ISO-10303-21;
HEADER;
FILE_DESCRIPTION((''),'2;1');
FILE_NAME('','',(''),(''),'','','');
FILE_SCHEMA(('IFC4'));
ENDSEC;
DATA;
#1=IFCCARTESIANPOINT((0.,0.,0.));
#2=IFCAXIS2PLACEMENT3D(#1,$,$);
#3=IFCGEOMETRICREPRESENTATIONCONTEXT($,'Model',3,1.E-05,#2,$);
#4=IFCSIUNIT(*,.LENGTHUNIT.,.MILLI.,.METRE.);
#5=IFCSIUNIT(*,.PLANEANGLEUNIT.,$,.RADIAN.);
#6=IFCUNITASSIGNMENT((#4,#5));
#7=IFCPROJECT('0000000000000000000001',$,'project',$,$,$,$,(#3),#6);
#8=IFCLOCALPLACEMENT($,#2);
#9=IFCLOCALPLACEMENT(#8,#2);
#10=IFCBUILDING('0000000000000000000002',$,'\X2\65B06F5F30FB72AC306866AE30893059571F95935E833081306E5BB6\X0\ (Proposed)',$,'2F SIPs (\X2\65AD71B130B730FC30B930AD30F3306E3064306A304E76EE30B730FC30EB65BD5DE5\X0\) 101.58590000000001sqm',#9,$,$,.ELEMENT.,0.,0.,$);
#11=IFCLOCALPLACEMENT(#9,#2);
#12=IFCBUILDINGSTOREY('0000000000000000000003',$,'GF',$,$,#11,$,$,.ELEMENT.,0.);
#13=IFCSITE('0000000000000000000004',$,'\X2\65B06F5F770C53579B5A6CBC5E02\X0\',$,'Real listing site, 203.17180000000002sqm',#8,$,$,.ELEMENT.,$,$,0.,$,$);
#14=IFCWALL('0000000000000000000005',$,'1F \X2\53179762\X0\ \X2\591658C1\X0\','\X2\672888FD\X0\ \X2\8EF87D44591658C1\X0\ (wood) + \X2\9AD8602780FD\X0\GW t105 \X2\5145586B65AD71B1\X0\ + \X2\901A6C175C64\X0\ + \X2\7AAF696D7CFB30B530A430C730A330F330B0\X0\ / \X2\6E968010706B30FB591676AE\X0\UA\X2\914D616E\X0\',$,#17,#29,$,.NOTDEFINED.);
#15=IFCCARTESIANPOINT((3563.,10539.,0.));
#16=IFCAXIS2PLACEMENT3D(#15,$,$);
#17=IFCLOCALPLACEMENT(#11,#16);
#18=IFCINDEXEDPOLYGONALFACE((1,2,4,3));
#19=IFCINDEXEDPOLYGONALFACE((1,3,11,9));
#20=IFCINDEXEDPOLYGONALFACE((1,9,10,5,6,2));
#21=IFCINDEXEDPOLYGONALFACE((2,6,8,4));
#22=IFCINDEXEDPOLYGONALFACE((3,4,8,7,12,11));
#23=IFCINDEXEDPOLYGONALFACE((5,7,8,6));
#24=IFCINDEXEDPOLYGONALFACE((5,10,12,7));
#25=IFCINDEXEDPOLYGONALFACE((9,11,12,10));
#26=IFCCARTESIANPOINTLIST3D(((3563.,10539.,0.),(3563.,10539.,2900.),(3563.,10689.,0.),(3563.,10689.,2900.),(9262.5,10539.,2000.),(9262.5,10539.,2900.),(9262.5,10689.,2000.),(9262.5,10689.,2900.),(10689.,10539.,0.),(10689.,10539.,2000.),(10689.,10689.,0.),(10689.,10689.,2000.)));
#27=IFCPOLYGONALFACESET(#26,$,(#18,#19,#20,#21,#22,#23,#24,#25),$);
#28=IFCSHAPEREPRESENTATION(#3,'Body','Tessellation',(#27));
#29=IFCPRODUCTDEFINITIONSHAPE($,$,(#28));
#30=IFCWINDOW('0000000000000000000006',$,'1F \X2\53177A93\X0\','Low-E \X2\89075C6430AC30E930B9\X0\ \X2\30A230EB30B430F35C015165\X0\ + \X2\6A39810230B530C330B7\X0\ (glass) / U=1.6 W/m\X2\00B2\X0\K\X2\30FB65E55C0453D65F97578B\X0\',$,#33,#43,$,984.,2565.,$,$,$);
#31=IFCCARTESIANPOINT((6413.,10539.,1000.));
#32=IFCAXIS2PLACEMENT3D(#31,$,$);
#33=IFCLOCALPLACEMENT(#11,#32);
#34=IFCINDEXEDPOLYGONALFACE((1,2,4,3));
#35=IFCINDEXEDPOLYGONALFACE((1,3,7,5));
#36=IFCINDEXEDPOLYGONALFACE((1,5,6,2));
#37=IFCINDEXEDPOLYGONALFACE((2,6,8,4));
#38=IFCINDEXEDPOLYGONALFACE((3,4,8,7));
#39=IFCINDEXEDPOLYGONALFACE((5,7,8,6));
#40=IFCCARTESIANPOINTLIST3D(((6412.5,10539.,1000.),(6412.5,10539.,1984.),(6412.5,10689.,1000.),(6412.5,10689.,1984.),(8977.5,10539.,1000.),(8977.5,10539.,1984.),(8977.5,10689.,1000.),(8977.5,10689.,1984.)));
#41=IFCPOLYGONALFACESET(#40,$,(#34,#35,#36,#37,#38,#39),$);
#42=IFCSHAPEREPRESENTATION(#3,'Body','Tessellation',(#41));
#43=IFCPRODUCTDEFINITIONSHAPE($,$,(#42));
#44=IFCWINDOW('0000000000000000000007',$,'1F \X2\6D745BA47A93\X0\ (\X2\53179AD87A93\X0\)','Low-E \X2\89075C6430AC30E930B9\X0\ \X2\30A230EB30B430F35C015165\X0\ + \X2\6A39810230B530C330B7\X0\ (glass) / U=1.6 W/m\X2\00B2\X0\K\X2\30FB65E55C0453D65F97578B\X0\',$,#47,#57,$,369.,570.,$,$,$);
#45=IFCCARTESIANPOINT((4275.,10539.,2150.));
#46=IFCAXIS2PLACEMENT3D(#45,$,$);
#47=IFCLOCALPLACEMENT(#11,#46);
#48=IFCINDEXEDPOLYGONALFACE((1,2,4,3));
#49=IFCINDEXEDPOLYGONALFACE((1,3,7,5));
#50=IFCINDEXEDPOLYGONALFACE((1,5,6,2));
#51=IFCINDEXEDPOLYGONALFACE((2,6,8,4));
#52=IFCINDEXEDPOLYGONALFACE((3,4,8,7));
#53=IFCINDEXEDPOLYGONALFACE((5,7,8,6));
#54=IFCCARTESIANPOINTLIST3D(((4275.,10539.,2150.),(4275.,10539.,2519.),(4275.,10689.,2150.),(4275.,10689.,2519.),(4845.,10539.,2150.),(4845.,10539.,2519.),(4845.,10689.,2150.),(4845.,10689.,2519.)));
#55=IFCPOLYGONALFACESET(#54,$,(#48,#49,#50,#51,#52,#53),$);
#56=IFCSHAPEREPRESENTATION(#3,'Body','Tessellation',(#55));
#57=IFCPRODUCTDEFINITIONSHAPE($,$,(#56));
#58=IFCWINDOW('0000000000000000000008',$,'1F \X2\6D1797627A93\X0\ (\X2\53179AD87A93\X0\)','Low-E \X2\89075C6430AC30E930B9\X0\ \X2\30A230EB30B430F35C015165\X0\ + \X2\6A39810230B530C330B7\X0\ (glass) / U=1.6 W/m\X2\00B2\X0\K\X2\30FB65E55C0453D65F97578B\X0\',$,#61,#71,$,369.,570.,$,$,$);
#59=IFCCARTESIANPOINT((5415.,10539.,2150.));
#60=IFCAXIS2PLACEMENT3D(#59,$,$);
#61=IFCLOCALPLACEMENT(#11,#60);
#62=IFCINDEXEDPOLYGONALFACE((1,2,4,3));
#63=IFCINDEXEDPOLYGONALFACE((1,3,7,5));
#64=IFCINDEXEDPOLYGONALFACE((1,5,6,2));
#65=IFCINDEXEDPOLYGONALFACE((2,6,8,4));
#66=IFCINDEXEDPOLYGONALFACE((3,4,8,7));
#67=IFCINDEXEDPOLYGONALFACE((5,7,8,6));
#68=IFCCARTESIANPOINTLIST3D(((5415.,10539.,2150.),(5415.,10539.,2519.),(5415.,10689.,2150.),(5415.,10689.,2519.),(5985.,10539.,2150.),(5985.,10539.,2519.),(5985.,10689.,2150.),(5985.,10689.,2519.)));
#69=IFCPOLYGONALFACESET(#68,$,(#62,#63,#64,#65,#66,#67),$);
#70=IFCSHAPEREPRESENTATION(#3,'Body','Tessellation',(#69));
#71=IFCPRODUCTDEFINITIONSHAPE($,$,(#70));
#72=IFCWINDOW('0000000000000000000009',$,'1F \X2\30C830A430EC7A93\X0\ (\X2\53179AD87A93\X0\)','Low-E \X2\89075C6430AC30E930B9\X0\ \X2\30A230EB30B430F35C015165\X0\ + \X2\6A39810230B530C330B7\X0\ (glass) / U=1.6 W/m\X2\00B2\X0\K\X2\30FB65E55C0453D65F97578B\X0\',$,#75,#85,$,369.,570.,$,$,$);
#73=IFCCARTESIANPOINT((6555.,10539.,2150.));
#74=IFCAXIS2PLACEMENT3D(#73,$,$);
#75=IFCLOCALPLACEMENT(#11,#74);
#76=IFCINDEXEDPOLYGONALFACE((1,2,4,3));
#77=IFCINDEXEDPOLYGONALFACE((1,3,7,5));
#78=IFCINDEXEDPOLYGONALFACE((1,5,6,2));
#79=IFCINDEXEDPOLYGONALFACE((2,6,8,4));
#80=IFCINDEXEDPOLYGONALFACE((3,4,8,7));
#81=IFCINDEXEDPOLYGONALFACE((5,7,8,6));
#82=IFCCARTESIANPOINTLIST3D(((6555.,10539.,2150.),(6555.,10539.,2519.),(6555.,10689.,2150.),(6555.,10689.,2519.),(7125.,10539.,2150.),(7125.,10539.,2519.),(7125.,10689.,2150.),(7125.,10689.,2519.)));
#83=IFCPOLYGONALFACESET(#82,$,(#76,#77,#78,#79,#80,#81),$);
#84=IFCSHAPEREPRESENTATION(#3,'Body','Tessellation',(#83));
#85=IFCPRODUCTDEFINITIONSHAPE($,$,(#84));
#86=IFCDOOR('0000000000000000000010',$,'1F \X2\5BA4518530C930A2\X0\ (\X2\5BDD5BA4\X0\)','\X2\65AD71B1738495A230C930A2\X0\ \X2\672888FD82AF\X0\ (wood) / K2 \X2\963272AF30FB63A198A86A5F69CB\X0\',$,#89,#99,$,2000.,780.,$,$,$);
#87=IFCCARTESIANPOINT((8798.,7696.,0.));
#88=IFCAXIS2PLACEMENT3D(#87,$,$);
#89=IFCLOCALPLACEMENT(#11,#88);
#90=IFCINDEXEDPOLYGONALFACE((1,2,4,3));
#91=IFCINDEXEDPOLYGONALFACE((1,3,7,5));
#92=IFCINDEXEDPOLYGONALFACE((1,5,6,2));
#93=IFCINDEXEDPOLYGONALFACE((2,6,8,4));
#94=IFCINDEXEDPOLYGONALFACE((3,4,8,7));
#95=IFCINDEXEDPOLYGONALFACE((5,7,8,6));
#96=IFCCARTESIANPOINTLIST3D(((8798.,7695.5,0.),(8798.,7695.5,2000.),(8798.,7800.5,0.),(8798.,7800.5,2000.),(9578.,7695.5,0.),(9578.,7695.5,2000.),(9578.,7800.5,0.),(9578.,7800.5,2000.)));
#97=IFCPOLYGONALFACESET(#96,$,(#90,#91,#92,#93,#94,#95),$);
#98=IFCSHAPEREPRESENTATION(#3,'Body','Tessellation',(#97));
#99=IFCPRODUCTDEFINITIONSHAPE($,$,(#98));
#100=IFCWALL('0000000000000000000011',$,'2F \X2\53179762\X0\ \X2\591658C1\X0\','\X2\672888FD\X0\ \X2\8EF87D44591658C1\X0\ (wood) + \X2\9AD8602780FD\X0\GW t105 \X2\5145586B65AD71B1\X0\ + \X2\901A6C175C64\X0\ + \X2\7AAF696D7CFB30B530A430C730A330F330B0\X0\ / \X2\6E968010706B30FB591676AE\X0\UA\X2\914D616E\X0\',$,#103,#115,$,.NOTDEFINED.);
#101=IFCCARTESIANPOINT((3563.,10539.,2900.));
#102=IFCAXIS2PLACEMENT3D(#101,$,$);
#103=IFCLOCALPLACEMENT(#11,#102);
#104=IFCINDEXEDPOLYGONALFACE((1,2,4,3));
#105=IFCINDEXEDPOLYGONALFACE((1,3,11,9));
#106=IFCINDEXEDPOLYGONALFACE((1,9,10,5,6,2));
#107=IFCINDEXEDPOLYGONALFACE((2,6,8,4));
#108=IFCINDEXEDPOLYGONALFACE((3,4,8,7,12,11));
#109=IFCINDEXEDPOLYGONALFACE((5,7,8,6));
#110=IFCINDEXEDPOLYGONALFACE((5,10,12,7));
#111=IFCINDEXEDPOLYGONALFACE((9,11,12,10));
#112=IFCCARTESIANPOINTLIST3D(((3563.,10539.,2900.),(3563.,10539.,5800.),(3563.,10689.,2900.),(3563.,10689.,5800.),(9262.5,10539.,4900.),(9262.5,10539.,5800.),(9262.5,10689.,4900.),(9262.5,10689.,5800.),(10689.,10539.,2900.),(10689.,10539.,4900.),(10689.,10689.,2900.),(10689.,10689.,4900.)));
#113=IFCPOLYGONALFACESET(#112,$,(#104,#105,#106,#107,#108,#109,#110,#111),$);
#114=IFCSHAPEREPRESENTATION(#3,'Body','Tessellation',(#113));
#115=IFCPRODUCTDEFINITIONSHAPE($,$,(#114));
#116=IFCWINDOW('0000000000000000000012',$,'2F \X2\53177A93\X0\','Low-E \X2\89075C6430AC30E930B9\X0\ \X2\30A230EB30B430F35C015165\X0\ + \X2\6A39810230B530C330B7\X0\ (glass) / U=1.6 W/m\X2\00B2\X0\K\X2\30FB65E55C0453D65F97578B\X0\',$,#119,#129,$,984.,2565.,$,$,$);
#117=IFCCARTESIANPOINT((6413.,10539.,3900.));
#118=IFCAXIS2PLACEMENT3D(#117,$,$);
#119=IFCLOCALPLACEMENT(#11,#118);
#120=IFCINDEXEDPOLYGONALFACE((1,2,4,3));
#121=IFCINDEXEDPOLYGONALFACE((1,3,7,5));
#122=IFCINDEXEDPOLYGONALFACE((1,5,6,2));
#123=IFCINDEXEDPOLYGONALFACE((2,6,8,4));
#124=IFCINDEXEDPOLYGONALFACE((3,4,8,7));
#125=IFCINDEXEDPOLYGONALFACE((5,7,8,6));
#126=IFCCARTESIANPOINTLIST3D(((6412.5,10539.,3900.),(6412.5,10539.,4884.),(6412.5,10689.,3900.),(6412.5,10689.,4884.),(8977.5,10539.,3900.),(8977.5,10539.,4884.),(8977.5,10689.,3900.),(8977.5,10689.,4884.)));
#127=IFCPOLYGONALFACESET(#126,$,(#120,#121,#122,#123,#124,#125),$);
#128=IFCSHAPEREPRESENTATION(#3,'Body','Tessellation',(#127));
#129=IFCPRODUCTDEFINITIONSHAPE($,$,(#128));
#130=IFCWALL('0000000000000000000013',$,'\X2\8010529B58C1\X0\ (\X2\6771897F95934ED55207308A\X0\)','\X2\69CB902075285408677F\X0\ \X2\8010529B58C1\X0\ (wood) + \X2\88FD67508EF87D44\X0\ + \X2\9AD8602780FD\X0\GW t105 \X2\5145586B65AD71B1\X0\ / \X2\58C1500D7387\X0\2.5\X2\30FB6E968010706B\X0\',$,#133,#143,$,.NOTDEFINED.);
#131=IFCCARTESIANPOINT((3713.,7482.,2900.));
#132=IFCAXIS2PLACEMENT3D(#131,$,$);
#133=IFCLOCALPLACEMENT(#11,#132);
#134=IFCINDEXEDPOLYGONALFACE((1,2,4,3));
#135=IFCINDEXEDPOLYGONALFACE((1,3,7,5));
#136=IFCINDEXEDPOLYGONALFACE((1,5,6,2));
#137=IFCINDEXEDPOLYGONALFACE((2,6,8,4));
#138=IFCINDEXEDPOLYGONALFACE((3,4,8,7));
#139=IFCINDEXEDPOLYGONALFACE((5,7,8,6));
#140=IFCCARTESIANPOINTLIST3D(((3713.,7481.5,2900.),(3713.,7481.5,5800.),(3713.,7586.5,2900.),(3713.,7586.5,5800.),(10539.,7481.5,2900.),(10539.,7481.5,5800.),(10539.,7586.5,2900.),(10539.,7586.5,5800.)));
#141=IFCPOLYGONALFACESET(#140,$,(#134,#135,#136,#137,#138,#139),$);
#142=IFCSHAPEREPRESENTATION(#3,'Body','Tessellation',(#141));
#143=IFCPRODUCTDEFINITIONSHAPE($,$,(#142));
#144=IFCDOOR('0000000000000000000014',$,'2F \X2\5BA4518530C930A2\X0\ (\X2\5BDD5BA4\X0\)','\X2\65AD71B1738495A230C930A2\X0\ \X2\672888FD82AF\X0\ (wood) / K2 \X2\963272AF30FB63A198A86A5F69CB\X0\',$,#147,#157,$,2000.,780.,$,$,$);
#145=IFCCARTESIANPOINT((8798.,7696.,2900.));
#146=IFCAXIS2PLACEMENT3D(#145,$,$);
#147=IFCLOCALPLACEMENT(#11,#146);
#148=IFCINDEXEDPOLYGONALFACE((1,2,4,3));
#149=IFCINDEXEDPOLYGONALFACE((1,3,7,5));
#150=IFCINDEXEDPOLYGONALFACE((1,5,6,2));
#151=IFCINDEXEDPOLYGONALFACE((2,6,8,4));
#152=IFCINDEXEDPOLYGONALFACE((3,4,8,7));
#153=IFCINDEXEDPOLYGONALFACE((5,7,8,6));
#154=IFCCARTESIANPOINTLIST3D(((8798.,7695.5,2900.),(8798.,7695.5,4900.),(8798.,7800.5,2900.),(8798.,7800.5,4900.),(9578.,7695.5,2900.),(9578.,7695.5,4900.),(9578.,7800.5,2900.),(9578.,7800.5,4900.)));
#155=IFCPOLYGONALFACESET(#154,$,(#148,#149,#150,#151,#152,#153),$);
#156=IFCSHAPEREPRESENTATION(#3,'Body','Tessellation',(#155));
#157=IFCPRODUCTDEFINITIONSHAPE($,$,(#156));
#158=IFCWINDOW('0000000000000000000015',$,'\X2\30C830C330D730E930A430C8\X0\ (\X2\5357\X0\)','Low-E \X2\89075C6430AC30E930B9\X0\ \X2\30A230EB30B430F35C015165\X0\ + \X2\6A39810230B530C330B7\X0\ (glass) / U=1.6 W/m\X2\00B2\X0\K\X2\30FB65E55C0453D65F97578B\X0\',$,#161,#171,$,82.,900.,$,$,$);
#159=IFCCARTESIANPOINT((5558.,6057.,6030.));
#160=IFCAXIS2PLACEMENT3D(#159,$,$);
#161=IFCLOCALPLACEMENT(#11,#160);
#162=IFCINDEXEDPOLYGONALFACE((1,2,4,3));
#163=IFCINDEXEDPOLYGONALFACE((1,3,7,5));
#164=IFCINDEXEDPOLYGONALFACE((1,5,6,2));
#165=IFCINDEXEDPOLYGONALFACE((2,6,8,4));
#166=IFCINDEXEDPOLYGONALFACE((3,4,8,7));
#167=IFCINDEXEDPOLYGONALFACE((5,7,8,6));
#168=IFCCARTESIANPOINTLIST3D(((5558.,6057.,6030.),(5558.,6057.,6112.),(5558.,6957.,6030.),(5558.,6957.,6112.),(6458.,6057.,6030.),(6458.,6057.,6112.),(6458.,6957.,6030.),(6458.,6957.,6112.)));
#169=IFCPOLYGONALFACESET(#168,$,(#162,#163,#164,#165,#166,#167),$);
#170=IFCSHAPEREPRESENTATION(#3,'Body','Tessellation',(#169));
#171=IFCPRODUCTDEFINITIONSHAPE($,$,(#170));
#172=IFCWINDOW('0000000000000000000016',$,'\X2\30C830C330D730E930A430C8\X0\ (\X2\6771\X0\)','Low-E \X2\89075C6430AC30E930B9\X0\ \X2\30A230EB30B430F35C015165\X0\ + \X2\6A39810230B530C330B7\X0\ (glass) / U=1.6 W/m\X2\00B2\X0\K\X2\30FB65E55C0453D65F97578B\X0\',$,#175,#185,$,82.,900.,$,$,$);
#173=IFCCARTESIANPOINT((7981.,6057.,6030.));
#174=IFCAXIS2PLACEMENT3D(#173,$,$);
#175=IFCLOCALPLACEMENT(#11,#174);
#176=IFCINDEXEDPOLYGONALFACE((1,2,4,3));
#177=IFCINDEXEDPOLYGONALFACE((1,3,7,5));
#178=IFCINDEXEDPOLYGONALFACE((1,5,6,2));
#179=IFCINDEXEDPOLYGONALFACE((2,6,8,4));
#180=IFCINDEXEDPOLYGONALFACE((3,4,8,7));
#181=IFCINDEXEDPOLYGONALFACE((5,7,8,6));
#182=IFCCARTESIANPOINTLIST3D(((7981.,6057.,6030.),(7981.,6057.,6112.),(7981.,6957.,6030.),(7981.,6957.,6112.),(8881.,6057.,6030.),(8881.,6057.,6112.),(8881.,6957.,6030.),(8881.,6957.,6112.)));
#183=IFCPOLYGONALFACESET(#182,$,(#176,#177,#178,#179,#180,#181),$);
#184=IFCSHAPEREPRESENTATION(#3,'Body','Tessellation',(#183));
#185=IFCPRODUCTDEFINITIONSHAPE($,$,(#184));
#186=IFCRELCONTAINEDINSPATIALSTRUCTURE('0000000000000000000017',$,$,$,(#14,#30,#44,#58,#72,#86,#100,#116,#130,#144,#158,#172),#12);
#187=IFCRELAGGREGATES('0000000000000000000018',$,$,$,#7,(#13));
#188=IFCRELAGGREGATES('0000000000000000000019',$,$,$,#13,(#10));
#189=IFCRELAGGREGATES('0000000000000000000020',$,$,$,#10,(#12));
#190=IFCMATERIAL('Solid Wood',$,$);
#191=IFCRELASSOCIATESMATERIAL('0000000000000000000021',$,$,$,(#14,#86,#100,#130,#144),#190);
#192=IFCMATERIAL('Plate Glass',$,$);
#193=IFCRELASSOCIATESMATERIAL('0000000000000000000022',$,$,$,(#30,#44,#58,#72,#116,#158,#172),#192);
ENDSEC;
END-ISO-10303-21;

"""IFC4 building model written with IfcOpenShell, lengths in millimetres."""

from ifc_helpers import new_model, si_unit, frame, frame_2d, origin, place, context, project, spatial, rectangle, extrude, material, element, fill, save


model = new_model("IFC4")

# Units and contexts
model_context = context("Model", 3, precision=1e-05, world=origin())
ifc_project = project(units=[si_unit("LENGTHUNIT", "METRE", prefix="MILLI"), si_unit("PLANEANGLEUNIT", "RADIAN")], contexts=[model_context])

# Site, building, storey
site_placement = place(None, origin())
site = spatial("IfcSite", under=ifc_project, at=site_placement, Name="新潟県南魚沼市", ObjectType="Real listing site, 203.17180000000002sqm", CompositionType="ELEMENT", RefElevation=0.0)
building_placement = place(site_placement, origin())
building = spatial("IfcBuilding", under=site, at=building_placement, Name="新潟・犬と暮らす土間広めの家 (Proposed)", ObjectType="2F SIPs (断熱シースキンのつなぎ目シール施工) 101.58590000000001sqm", CompositionType="ELEMENT", ElevationOfRefHeight=0.0, ElevationOfTerrain=0.0)
storey_placement = place(building_placement, origin())
storey = spatial("IfcBuildingStorey", under=building, at=storey_placement, Name="GF", CompositionType="ELEMENT", Elevation=0.0)

# Wall, openings, windows
ifc_material_1 = material(Name="Solid Wood")
wall_1_placement = place(storey_placement, frame((3563.0, 10539.0, 0.0)))
wall_1 = element("IfcWall", 1, at=wall_1_placement, inside=storey, material=ifc_material_1, Name="1F 北面 外壁", Description="木製 軸組外壁 (wood) + 高性能GW t105 充填断熱 + 通気層 + 窯業系サイディング / 準耐火・外皮UA配慮", PredefinedType="NOTDEFINED", context=model_context, shape_type="SweptSolid", body=[
    extrude(rectangle(XDim=7126.0, YDim=150.0, at=frame_2d((3563.0, 75.0))), frame((3563.0, 10539.0, 0.0)), (0.0, 0.0, 1.0), 2900.0),
])
opening_1_placement = place(storey_placement, frame((6413.0, 10539.0, 1000.0)))
opening_1 = element("IfcOpeningElement", 2, at=opening_1_placement, cuts=wall_1, PredefinedType="NOTDEFINED", context=model_context, shape_type="SweptSolid", body=[
    extrude(rectangle(XDim=2565.0, YDim=150.0, at=frame_2d((1282.0, 75.0))), frame((6413.0, 10539.0, 1000.0)), (0.0, 0.0, 1.0), 984.0),
])
opening_2_placement = place(storey_placement, frame((4275.0, 10539.0, 2150.0)))
opening_2 = element("IfcOpeningElement", 3, at=opening_2_placement, cuts=wall_1, PredefinedType="NOTDEFINED", context=model_context, shape_type="SweptSolid", body=[
    extrude(rectangle(XDim=570.0, YDim=150.0, at=frame_2d((285.0, 75.0))), frame((4275.0, 10539.0, 2150.0)), (0.0, 0.0, 1.0), 369.0),
])
opening_3_placement = place(storey_placement, frame((5415.0, 10539.0, 2150.0)))
opening_3 = element("IfcOpeningElement", 4, at=opening_3_placement, cuts=wall_1, PredefinedType="NOTDEFINED", context=model_context, shape_type="SweptSolid", body=[
    extrude(rectangle(XDim=570.0, YDim=150.0, at=frame_2d((285.0, 75.0))), frame((5415.0, 10539.0, 2150.0)), (0.0, 0.0, 1.0), 369.0),
])
opening_4_placement = place(storey_placement, frame((6555.0, 10539.0, 2150.0)))
opening_4 = element("IfcOpeningElement", 5, at=opening_4_placement, cuts=wall_1, PredefinedType="NOTDEFINED", context=model_context, shape_type="SweptSolid", body=[
    extrude(rectangle(XDim=570.0, YDim=150.0, at=frame_2d((285.0, 75.0))), frame((6555.0, 10539.0, 2150.0)), (0.0, 0.0, 1.0), 369.0),
])
ifc_material_2 = material(Name="Plate Glass")
window_1_placement = place(storey_placement, frame((6413.0, 10539.0, 1000.0)))
window_1 = element("IfcWindow", 6, at=window_1_placement, inside=storey, material=ifc_material_2, Name="1F 北窓", Description="Low-E 複層ガラス アルゴン封入 + 樹脂サッシ (glass) / U=1.6 W/m²K・日射取得型", OverallHeight=984.0, OverallWidth=2565.0, context=model_context, shape_type="SweptSolid", body=[
    extrude(rectangle(XDim=2565.0, YDim=150.0, at=frame_2d((1282.0, 75.0))), frame((6413.0, 10539.0, 1000.0)), (0.0, 0.0, 1.0), 984.0),
])
fill(opening_1, window_1)
window_2_placement = place(storey_placement, frame((4275.0, 10539.0, 2150.0)))
window_2 = element("IfcWindow", 7, at=window_2_placement, inside=storey, material=ifc_material_2, Name="1F 浴室窓 (北高窓)", Description="Low-E 複層ガラス アルゴン封入 + 樹脂サッシ (glass) / U=1.6 W/m²K・日射取得型", OverallHeight=369.0, OverallWidth=570.0, context=model_context, shape_type="SweptSolid", body=[
    extrude(rectangle(XDim=570.0, YDim=150.0, at=frame_2d((285.0, 75.0))), frame((4275.0, 10539.0, 2150.0)), (0.0, 0.0, 1.0), 369.0),
])
fill(opening_2, window_2)
window_3_placement = place(storey_placement, frame((5415.0, 10539.0, 2150.0)))
window_3 = element("IfcWindow", 8, at=window_3_placement, inside=storey, material=ifc_material_2, Name="1F 洗面窓 (北高窓)", Description="Low-E 複層ガラス アルゴン封入 + 樹脂サッシ (glass) / U=1.6 W/m²K・日射取得型", OverallHeight=369.0, OverallWidth=570.0, context=model_context, shape_type="SweptSolid", body=[
    extrude(rectangle(XDim=570.0, YDim=150.0, at=frame_2d((285.0, 75.0))), frame((5415.0, 10539.0, 2150.0)), (0.0, 0.0, 1.0), 369.0),
])
fill(opening_3, window_3)
window_4_placement = place(storey_placement, frame((6555.0, 10539.0, 2150.0)))
window_4 = element("IfcWindow", 9, at=window_4_placement, inside=storey, material=ifc_material_2, Name="1F トイレ窓 (北高窓)", Description="Low-E 複層ガラス アルゴン封入 + 樹脂サッシ (glass) / U=1.6 W/m²K・日射取得型", OverallHeight=369.0, OverallWidth=570.0, context=model_context, shape_type="SweptSolid", body=[
    extrude(rectangle(XDim=570.0, YDim=150.0, at=frame_2d((285.0, 75.0))), frame((6555.0, 10539.0, 2150.0)), (0.0, 0.0, 1.0), 369.0),
])
fill(opening_4, window_4)

# Door
door_1_placement = place(storey_placement, frame((8798.0, 7696.0, 0.0)))
element("IfcDoor", 10, at=door_1_placement, inside=storey, material=ifc_material_1, Name="1F 室内ドア (寝室)", Description="断熱玄関ドア 木製芯 (wood) / K2 防犯・採風機構", OverallHeight=2000.0, OverallWidth=780.0, context=model_context, shape_type="SweptSolid", body=[
    extrude(rectangle(XDim=780.0, YDim=105.0, at=frame_2d((390.0, 52.0))), frame((8798.0, 7696.0, 0.0)), (0.0, 0.0, 1.0), 2000.0),
])

# Wall, opening, window
wall_2_placement = place(storey_placement, frame((3563.0, 10539.0, 2900.0)))
wall_2 = element("IfcWall", 11, at=wall_2_placement, inside=storey, material=ifc_material_1, Name="2F 北面 外壁", Description="木製 軸組外壁 (wood) + 高性能GW t105 充填断熱 + 通気層 + 窯業系サイディング / 準耐火・外皮UA配慮", PredefinedType="NOTDEFINED", context=model_context, shape_type="SweptSolid", body=[
    extrude(rectangle(XDim=7126.0, YDim=150.0, at=frame_2d((3563.0, 75.0))), frame((3563.0, 10539.0, 2900.0)), (0.0, 0.0, 1.0), 2900.0),
])
opening_5_placement = place(storey_placement, frame((6413.0, 10539.0, 3900.0)))
opening_5 = element("IfcOpeningElement", 12, at=opening_5_placement, cuts=wall_2, PredefinedType="NOTDEFINED", context=model_context, shape_type="SweptSolid", body=[
    extrude(rectangle(XDim=2565.0, YDim=150.0, at=frame_2d((1282.0, 75.0))), frame((6413.0, 10539.0, 3900.0)), (0.0, 0.0, 1.0), 984.0),
])
window_5_placement = place(storey_placement, frame((6413.0, 10539.0, 3900.0)))
window_5 = element("IfcWindow", 13, at=window_5_placement, inside=storey, material=ifc_material_2, Name="2F 北窓", Description="Low-E 複層ガラス アルゴン封入 + 樹脂サッシ (glass) / U=1.6 W/m²K・日射取得型", OverallHeight=984.0, OverallWidth=2565.0, context=model_context, shape_type="SweptSolid", body=[
    extrude(rectangle(XDim=2565.0, YDim=150.0, at=frame_2d((1282.0, 75.0))), frame((6413.0, 10539.0, 3900.0)), (0.0, 0.0, 1.0), 984.0),
])
fill(opening_5, window_5)

# Wall
wall_3_placement = place(storey_placement, frame((3713.0, 7482.0, 2900.0)))
element("IfcWall", 14, at=wall_3_placement, inside=storey, material=ifc_material_1, Name="耐力壁 (東西間仕切り)", Description="構造用合板 耐力壁 (wood) + 製材軸組 + 高性能GW t105 充填断熱 / 壁倍率2.5・準耐火", PredefinedType="NOTDEFINED", context=model_context, shape_type="SweptSolid", body=[
    extrude(rectangle(XDim=6826.0, YDim=105.0, at=frame_2d((3413.0, 52.0))), frame((3713.0, 7482.0, 2900.0)), (0.0, 0.0, 1.0), 2900.0),
])

# Door
door_2_placement = place(storey_placement, frame((8798.0, 7696.0, 2900.0)))
element("IfcDoor", 15, at=door_2_placement, inside=storey, material=ifc_material_1, Name="2F 室内ドア (寝室)", Description="断熱玄関ドア 木製芯 (wood) / K2 防犯・採風機構", OverallHeight=2000.0, OverallWidth=780.0, context=model_context, shape_type="SweptSolid", body=[
    extrude(rectangle(XDim=780.0, YDim=105.0, at=frame_2d((390.0, 52.0))), frame((8798.0, 7696.0, 2900.0)), (0.0, 0.0, 1.0), 2000.0),
])

# Windows
window_6_placement = place(storey_placement, frame((5558.0, 6057.0, 6030.0)))
element("IfcWindow", 16, at=window_6_placement, inside=storey, material=ifc_material_2, Name="トップライト (南)", Description="Low-E 複層ガラス アルゴン封入 + 樹脂サッシ (glass) / U=1.6 W/m²K・日射取得型", OverallHeight=82.0, OverallWidth=900.0, context=model_context, shape_type="SweptSolid", body=[
    extrude(rectangle(XDim=900.0, YDim=900.0, at=frame_2d((450.0, 450.0))), frame((5558.0, 6057.0, 6030.0)), (0.0, 0.0, 1.0), 82.0),
])
window_7_placement = place(storey_placement, frame((7981.0, 6057.0, 6030.0)))
element("IfcWindow", 17, at=window_7_placement, inside=storey, material=ifc_material_2, Name="トップライト (東)", Description="Low-E 複層ガラス アルゴン封入 + 樹脂サッシ (glass) / U=1.6 W/m²K・日射取得型", OverallHeight=82.0, OverallWidth=900.0, context=model_context, shape_type="SweptSolid", body=[
    extrude(rectangle(XDim=900.0, YDim=900.0, at=frame_2d((450.0, 450.0))), frame((7981.0, 6057.0, 6030.0)), (0.0, 0.0, 1.0), 82.0),
])

save(model, "model.ifc")
